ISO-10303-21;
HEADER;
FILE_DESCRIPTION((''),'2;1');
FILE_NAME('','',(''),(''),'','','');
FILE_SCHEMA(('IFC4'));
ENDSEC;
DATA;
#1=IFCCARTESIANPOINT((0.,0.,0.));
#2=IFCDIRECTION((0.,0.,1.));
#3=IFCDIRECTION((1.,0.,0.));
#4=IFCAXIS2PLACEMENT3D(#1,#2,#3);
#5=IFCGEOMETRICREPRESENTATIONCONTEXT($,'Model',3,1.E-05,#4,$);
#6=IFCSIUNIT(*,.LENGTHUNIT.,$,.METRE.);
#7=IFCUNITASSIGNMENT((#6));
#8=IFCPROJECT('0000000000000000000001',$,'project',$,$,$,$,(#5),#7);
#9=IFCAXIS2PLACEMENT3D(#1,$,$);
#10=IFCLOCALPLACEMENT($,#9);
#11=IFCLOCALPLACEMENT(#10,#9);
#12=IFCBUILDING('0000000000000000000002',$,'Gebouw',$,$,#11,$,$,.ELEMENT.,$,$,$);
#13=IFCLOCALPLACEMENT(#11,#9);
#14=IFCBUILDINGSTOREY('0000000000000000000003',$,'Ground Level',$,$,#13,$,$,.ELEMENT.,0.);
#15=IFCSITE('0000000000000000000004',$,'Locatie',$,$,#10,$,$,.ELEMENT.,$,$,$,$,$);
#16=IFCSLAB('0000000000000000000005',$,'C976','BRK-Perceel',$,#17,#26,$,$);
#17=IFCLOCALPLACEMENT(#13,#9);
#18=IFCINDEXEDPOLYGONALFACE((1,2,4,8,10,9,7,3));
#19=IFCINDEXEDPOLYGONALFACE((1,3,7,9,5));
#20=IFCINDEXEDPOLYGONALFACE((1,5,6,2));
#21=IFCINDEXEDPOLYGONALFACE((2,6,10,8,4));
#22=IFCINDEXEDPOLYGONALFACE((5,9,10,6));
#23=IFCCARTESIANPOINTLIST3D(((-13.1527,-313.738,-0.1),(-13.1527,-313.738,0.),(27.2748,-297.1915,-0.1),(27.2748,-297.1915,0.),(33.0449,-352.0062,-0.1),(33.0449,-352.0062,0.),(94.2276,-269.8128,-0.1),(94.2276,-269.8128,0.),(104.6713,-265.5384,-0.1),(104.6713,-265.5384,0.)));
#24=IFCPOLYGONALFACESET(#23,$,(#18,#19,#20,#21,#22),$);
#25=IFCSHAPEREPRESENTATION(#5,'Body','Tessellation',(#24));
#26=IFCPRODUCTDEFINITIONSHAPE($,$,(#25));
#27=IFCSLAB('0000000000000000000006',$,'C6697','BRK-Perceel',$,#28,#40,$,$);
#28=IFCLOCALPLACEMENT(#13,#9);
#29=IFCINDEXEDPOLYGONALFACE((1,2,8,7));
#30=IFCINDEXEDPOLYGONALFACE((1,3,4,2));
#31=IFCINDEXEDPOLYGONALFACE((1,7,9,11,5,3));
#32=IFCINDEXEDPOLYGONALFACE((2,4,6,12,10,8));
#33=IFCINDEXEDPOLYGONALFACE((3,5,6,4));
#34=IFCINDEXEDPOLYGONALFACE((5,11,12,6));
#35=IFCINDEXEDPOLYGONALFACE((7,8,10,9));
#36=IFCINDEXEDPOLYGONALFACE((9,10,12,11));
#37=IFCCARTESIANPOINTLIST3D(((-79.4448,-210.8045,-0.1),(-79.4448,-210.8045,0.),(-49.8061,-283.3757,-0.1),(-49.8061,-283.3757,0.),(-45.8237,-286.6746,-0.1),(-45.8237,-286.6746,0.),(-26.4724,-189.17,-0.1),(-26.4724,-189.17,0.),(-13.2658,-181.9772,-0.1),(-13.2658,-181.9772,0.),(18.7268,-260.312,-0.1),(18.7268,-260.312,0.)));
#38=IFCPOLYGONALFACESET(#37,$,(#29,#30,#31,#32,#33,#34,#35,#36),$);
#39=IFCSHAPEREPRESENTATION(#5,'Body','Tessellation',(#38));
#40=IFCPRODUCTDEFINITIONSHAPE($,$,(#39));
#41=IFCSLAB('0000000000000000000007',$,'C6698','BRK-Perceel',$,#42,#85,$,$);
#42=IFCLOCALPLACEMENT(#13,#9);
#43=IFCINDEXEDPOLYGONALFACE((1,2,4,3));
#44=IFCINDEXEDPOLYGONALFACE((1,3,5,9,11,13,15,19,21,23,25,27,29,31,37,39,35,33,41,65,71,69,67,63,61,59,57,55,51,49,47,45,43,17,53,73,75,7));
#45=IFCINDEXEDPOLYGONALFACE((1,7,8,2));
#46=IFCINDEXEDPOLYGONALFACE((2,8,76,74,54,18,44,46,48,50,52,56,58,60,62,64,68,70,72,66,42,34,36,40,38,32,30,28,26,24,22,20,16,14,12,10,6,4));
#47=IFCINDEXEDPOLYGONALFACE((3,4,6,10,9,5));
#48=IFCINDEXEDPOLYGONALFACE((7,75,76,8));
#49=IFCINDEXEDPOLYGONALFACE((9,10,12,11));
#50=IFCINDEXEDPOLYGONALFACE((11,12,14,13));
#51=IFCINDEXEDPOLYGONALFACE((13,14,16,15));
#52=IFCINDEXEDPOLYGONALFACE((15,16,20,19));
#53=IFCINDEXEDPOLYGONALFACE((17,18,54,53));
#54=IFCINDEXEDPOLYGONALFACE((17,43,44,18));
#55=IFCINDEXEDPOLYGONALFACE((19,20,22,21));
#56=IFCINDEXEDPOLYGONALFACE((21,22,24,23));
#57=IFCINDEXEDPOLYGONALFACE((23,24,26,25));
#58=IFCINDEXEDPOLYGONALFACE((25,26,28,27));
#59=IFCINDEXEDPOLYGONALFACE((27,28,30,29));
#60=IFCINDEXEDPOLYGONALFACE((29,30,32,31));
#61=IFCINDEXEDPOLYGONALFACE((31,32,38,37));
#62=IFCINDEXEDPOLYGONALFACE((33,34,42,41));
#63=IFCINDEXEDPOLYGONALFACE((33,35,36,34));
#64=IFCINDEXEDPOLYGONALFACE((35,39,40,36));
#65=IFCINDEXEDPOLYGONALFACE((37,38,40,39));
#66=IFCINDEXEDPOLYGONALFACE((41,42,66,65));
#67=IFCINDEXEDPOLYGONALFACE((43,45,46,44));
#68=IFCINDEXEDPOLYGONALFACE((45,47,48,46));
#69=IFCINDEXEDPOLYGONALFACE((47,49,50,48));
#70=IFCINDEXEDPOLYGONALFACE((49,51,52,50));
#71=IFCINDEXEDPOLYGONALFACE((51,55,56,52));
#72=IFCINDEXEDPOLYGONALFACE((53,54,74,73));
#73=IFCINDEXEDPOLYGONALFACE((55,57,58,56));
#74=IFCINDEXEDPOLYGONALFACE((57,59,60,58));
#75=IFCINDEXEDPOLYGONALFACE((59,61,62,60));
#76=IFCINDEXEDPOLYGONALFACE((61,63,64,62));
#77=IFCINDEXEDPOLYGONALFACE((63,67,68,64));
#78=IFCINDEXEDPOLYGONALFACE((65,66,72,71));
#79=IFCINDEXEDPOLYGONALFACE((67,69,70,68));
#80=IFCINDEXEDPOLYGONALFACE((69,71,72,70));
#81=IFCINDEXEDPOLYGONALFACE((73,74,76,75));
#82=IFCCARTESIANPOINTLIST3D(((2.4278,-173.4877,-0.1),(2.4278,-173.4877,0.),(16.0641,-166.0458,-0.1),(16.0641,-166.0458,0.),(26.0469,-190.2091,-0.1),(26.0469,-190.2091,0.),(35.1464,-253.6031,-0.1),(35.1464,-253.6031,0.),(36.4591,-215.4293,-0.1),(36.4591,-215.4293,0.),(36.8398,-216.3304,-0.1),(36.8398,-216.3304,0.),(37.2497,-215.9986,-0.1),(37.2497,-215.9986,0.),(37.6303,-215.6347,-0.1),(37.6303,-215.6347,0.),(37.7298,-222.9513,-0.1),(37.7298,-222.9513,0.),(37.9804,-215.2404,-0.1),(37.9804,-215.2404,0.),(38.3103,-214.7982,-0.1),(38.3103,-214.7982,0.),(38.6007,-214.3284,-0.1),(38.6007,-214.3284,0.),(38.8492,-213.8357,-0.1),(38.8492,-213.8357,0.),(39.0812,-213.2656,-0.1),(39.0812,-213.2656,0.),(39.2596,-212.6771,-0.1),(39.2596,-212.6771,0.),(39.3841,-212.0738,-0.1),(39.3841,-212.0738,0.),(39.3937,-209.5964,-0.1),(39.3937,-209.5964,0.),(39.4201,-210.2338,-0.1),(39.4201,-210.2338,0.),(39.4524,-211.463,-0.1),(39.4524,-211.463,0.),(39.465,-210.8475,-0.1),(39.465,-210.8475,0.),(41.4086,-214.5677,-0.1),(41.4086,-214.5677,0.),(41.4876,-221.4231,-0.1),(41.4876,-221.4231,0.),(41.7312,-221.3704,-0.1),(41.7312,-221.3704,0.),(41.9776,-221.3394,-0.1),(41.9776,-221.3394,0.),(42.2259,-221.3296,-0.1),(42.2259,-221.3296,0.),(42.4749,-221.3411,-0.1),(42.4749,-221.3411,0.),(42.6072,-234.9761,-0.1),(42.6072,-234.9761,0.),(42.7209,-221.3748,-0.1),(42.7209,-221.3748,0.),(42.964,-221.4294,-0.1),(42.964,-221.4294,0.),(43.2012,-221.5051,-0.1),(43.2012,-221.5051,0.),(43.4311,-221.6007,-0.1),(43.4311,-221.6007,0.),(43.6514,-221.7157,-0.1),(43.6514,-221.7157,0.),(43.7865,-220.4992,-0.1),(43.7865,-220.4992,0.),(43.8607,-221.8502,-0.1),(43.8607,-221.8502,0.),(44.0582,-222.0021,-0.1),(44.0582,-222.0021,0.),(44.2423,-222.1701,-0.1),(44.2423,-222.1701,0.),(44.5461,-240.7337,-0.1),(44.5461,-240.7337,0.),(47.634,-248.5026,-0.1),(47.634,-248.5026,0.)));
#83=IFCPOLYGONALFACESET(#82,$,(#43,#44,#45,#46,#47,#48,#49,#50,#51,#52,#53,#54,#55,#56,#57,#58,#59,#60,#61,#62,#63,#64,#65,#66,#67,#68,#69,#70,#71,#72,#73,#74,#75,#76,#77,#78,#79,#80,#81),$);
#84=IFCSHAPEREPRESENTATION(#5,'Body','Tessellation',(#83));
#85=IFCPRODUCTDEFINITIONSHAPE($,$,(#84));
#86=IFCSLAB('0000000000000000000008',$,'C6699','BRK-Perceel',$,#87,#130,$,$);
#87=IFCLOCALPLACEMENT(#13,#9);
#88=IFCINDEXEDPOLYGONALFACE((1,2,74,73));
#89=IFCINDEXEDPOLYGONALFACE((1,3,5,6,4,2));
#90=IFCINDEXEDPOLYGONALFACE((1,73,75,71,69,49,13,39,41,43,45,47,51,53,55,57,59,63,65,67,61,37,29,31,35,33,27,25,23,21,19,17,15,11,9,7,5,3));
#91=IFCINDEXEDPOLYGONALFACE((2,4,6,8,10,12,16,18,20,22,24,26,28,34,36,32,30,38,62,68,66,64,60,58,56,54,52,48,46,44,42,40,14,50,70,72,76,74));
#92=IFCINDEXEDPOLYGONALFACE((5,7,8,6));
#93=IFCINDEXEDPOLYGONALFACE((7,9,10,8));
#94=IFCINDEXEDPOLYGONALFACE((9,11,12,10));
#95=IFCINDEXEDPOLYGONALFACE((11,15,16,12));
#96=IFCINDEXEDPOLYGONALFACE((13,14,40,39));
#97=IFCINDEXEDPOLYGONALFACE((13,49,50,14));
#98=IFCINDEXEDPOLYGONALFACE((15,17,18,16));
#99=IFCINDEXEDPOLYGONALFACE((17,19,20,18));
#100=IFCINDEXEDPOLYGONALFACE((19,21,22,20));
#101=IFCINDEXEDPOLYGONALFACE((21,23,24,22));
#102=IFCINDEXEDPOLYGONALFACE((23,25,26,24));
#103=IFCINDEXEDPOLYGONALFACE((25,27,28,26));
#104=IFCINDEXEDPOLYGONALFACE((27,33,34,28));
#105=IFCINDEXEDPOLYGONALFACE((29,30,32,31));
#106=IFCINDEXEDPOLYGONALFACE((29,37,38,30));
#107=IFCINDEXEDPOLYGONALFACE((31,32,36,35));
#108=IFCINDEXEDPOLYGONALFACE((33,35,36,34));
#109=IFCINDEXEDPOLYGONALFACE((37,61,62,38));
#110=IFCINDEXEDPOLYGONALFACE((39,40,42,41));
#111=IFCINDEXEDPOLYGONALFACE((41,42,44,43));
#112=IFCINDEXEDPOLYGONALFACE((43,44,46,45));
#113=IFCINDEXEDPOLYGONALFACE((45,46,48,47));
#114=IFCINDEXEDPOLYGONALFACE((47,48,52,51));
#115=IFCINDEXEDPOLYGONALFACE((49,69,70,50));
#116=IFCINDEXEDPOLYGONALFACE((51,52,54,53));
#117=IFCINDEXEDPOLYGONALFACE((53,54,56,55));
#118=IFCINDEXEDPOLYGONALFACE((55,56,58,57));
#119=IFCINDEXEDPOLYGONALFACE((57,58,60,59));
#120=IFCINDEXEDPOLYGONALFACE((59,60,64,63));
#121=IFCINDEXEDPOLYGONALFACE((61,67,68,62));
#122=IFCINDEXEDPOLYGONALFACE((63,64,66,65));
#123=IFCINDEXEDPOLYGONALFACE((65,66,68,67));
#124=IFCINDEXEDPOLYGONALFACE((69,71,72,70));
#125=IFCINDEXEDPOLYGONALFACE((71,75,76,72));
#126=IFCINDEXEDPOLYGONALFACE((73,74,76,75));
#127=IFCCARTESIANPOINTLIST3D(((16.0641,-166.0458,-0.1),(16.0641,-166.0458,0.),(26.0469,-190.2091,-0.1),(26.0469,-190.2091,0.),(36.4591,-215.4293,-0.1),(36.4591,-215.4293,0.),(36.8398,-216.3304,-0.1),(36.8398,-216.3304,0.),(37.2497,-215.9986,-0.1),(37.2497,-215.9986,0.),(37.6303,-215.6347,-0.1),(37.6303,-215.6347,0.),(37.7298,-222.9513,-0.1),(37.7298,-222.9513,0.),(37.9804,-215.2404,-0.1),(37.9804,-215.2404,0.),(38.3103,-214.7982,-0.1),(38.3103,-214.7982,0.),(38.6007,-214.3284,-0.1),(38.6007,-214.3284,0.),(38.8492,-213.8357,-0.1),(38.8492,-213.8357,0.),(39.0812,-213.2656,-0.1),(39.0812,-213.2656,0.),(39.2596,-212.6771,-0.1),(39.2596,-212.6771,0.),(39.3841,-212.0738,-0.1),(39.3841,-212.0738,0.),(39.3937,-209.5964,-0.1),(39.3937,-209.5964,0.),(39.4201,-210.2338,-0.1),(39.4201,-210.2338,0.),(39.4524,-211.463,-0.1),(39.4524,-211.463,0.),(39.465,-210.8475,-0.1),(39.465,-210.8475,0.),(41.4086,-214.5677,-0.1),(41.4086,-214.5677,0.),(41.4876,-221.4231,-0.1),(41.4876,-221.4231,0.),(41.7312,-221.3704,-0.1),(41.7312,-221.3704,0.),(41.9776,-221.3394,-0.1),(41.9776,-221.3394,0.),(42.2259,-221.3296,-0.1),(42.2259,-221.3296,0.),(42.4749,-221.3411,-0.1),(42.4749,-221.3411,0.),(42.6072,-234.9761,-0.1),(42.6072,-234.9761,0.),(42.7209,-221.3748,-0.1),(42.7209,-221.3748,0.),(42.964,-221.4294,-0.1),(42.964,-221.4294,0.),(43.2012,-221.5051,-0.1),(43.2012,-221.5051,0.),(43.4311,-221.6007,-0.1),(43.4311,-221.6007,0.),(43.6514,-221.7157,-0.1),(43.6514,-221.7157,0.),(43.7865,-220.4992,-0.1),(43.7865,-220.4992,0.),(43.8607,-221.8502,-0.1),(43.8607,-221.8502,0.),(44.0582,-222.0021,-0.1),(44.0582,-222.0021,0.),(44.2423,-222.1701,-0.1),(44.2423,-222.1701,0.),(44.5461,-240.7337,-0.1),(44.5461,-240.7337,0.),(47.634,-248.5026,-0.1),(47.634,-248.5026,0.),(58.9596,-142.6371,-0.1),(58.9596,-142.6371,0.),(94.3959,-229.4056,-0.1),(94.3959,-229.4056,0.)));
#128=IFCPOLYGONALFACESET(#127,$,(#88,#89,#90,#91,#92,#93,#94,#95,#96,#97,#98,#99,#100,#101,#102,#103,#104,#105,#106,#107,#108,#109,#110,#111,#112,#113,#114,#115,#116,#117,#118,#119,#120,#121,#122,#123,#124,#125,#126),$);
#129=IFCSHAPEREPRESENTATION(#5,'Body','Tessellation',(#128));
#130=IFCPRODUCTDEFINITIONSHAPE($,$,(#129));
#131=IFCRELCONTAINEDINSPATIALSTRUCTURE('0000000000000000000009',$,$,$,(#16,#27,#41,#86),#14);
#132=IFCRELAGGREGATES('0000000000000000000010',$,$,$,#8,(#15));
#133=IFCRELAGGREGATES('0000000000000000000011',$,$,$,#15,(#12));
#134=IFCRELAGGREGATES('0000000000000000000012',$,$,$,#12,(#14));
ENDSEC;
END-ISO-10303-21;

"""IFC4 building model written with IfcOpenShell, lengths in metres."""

from ifc_helpers import new_model, si_unit, frame, origin, origin_with_axes, place, context, project, spatial, polyline, outline, extrude, element, save


model = new_model("IFC4")

# Units and contexts
model_context = context("Model", 3, precision=1e-05, world=origin_with_axes())
ifc_project = project(units=[si_unit("LENGTHUNIT", "METRE")], contexts=[model_context])

# Site, building, storey
site_placement = place(None, origin())
site = spatial("IfcSite", under=ifc_project, at=site_placement, Name="Locatie", CompositionType="ELEMENT")
building_placement = place(site_placement, origin())
building = spatial("IfcBuilding", under=site, at=building_placement, Name="Gebouw", CompositionType="ELEMENT")
storey_placement = place(building_placement, origin())
storey = spatial("IfcBuildingStorey", under=building, at=storey_placement, Name="Ground Level", CompositionType="ELEMENT", Elevation=0.0)

# Slabs
slab_1_placement = place(storey_placement, origin())
element("IfcSlab", 1, at=slab_1_placement, inside=storey, Name="C976", Description="BRK-Perceel", context=model_context, shape_type="SweptSolid", body=[
    extrude(outline(polyline([(27.2748, -297.1915), (94.2276, -269.8128), (104.6713, -265.5384), (33.0449, -352.0062), (-13.1527, -313.738), (27.2748, -297.1915)])), frame((0.0, 0.0, -0.1), z_axis=(0.0, 0.0, 1.0), x_axis=(1.0, 0.0, 0.0)), (0.0, 0.0, 1.0), 0.1),
])
slab_2_placement = place(storey_placement, origin())
element("IfcSlab", 2, at=slab_2_placement, inside=storey, Name="C6697", Description="BRK-Perceel", context=model_context, shape_type="SweptSolid", body=[
    extrude(outline(polyline([(-79.4448, -210.8045), (-26.4724, -189.17), (-13.2658, -181.9772), (18.7268, -260.312), (-45.8237, -286.6746), (-49.8061, -283.3757), (-79.4448, -210.8045)])), frame((0.0, 0.0, -0.1), z_axis=(0.0, 0.0, 1.0), x_axis=(1.0, 0.0, 0.0)), (0.0, 0.0, 1.0), 0.1),
])
slab_3_placement = place(storey_placement, origin())
element("IfcSlab", 3, at=slab_3_placement, inside=storey, Name="C6698", Description="BRK-Perceel", context=model_context, shape_type="SweptSolid", body=[
    extrude(outline(polyline([(35.1464, -253.6031), (2.4278, -173.4877), (16.0641, -166.0458), (26.0469, -190.2091), (36.4591, -215.4293), (36.8398, -216.3304), (37.2497, -215.9986), (37.6303, -215.6347), (37.9804, -215.2404), (38.3103, -214.7982), (38.6007, -214.3284), (38.8492, -213.8357), (39.0812, -213.2656), (39.2596, -212.6771), (39.3841, -212.0738), (39.4524, -211.463), (39.465, -210.8475), (39.4201, -210.2338), (39.3937, -209.5964), (41.4086, -214.5677), (43.7865, -220.4992), (44.2423, -222.1701), (44.0582, -222.0021), (43.8607, -221.8502), (43.6514, -221.7157), (43.4311, -221.6007), (43.2012, -221.5051), (42.964, -221.4294), (42.7209, -221.3748), (42.4749, -221.3411), (42.2259, -221.3296), (41.9776, -221.3394), (41.7312, -221.3704), (41.4876, -221.4231), (37.7298, -222.9513), (42.6072, -234.9761), (44.5461, -240.7337), (47.634, -248.5026), (35.1464, -253.6031)])), frame((0.0, 0.0, -0.1), z_axis=(0.0, 0.0, 1.0), x_axis=(1.0, 0.0, 0.0)), (0.0, 0.0, 1.0), 0.1),
])
slab_4_placement = place(storey_placement, origin())
element("IfcSlab", 4, at=slab_4_placement, inside=storey, Name="C6699", Description="BRK-Perceel", context=model_context, shape_type="SweptSolid", body=[
    extrude(outline(polyline([(42.6072, -234.9761), (37.7298, -222.9513), (41.4876, -221.4231), (41.7312, -221.3704), (41.9776, -221.3394), (42.2259, -221.3296), (42.4749, -221.3411), (42.7209, -221.3748), (42.964, -221.4294), (43.2012, -221.5051), (43.4311, -221.6007), (43.6514, -221.7157), (43.8607, -221.8502), (44.0582, -222.0021), (44.2423, -222.1701), (43.7865, -220.4992), (41.4086, -214.5677), (39.3937, -209.5964), (39.4201, -210.2338), (39.465, -210.8475), (39.4524, -211.463), (39.3841, -212.0738), (39.2596, -212.6771), (39.0812, -213.2656), (38.8492, -213.8357), (38.6007, -214.3284), (38.3103, -214.7982), (37.9804, -215.2404), (37.6303, -215.6347), (37.2497, -215.9986), (36.8398, -216.3304), (36.4591, -215.4293), (26.0469, -190.2091), (16.0641, -166.0458), (58.9596, -142.6371), (94.3959, -229.4056), (47.634, -248.5026), (44.5461, -240.7337), (42.6072, -234.9761)])), frame((0.0, 0.0, -0.1), z_axis=(0.0, 0.0, 1.0), x_axis=(1.0, 0.0, 0.0)), (0.0, 0.0, 1.0), 0.1),
])

save(model, "model.ifc")
